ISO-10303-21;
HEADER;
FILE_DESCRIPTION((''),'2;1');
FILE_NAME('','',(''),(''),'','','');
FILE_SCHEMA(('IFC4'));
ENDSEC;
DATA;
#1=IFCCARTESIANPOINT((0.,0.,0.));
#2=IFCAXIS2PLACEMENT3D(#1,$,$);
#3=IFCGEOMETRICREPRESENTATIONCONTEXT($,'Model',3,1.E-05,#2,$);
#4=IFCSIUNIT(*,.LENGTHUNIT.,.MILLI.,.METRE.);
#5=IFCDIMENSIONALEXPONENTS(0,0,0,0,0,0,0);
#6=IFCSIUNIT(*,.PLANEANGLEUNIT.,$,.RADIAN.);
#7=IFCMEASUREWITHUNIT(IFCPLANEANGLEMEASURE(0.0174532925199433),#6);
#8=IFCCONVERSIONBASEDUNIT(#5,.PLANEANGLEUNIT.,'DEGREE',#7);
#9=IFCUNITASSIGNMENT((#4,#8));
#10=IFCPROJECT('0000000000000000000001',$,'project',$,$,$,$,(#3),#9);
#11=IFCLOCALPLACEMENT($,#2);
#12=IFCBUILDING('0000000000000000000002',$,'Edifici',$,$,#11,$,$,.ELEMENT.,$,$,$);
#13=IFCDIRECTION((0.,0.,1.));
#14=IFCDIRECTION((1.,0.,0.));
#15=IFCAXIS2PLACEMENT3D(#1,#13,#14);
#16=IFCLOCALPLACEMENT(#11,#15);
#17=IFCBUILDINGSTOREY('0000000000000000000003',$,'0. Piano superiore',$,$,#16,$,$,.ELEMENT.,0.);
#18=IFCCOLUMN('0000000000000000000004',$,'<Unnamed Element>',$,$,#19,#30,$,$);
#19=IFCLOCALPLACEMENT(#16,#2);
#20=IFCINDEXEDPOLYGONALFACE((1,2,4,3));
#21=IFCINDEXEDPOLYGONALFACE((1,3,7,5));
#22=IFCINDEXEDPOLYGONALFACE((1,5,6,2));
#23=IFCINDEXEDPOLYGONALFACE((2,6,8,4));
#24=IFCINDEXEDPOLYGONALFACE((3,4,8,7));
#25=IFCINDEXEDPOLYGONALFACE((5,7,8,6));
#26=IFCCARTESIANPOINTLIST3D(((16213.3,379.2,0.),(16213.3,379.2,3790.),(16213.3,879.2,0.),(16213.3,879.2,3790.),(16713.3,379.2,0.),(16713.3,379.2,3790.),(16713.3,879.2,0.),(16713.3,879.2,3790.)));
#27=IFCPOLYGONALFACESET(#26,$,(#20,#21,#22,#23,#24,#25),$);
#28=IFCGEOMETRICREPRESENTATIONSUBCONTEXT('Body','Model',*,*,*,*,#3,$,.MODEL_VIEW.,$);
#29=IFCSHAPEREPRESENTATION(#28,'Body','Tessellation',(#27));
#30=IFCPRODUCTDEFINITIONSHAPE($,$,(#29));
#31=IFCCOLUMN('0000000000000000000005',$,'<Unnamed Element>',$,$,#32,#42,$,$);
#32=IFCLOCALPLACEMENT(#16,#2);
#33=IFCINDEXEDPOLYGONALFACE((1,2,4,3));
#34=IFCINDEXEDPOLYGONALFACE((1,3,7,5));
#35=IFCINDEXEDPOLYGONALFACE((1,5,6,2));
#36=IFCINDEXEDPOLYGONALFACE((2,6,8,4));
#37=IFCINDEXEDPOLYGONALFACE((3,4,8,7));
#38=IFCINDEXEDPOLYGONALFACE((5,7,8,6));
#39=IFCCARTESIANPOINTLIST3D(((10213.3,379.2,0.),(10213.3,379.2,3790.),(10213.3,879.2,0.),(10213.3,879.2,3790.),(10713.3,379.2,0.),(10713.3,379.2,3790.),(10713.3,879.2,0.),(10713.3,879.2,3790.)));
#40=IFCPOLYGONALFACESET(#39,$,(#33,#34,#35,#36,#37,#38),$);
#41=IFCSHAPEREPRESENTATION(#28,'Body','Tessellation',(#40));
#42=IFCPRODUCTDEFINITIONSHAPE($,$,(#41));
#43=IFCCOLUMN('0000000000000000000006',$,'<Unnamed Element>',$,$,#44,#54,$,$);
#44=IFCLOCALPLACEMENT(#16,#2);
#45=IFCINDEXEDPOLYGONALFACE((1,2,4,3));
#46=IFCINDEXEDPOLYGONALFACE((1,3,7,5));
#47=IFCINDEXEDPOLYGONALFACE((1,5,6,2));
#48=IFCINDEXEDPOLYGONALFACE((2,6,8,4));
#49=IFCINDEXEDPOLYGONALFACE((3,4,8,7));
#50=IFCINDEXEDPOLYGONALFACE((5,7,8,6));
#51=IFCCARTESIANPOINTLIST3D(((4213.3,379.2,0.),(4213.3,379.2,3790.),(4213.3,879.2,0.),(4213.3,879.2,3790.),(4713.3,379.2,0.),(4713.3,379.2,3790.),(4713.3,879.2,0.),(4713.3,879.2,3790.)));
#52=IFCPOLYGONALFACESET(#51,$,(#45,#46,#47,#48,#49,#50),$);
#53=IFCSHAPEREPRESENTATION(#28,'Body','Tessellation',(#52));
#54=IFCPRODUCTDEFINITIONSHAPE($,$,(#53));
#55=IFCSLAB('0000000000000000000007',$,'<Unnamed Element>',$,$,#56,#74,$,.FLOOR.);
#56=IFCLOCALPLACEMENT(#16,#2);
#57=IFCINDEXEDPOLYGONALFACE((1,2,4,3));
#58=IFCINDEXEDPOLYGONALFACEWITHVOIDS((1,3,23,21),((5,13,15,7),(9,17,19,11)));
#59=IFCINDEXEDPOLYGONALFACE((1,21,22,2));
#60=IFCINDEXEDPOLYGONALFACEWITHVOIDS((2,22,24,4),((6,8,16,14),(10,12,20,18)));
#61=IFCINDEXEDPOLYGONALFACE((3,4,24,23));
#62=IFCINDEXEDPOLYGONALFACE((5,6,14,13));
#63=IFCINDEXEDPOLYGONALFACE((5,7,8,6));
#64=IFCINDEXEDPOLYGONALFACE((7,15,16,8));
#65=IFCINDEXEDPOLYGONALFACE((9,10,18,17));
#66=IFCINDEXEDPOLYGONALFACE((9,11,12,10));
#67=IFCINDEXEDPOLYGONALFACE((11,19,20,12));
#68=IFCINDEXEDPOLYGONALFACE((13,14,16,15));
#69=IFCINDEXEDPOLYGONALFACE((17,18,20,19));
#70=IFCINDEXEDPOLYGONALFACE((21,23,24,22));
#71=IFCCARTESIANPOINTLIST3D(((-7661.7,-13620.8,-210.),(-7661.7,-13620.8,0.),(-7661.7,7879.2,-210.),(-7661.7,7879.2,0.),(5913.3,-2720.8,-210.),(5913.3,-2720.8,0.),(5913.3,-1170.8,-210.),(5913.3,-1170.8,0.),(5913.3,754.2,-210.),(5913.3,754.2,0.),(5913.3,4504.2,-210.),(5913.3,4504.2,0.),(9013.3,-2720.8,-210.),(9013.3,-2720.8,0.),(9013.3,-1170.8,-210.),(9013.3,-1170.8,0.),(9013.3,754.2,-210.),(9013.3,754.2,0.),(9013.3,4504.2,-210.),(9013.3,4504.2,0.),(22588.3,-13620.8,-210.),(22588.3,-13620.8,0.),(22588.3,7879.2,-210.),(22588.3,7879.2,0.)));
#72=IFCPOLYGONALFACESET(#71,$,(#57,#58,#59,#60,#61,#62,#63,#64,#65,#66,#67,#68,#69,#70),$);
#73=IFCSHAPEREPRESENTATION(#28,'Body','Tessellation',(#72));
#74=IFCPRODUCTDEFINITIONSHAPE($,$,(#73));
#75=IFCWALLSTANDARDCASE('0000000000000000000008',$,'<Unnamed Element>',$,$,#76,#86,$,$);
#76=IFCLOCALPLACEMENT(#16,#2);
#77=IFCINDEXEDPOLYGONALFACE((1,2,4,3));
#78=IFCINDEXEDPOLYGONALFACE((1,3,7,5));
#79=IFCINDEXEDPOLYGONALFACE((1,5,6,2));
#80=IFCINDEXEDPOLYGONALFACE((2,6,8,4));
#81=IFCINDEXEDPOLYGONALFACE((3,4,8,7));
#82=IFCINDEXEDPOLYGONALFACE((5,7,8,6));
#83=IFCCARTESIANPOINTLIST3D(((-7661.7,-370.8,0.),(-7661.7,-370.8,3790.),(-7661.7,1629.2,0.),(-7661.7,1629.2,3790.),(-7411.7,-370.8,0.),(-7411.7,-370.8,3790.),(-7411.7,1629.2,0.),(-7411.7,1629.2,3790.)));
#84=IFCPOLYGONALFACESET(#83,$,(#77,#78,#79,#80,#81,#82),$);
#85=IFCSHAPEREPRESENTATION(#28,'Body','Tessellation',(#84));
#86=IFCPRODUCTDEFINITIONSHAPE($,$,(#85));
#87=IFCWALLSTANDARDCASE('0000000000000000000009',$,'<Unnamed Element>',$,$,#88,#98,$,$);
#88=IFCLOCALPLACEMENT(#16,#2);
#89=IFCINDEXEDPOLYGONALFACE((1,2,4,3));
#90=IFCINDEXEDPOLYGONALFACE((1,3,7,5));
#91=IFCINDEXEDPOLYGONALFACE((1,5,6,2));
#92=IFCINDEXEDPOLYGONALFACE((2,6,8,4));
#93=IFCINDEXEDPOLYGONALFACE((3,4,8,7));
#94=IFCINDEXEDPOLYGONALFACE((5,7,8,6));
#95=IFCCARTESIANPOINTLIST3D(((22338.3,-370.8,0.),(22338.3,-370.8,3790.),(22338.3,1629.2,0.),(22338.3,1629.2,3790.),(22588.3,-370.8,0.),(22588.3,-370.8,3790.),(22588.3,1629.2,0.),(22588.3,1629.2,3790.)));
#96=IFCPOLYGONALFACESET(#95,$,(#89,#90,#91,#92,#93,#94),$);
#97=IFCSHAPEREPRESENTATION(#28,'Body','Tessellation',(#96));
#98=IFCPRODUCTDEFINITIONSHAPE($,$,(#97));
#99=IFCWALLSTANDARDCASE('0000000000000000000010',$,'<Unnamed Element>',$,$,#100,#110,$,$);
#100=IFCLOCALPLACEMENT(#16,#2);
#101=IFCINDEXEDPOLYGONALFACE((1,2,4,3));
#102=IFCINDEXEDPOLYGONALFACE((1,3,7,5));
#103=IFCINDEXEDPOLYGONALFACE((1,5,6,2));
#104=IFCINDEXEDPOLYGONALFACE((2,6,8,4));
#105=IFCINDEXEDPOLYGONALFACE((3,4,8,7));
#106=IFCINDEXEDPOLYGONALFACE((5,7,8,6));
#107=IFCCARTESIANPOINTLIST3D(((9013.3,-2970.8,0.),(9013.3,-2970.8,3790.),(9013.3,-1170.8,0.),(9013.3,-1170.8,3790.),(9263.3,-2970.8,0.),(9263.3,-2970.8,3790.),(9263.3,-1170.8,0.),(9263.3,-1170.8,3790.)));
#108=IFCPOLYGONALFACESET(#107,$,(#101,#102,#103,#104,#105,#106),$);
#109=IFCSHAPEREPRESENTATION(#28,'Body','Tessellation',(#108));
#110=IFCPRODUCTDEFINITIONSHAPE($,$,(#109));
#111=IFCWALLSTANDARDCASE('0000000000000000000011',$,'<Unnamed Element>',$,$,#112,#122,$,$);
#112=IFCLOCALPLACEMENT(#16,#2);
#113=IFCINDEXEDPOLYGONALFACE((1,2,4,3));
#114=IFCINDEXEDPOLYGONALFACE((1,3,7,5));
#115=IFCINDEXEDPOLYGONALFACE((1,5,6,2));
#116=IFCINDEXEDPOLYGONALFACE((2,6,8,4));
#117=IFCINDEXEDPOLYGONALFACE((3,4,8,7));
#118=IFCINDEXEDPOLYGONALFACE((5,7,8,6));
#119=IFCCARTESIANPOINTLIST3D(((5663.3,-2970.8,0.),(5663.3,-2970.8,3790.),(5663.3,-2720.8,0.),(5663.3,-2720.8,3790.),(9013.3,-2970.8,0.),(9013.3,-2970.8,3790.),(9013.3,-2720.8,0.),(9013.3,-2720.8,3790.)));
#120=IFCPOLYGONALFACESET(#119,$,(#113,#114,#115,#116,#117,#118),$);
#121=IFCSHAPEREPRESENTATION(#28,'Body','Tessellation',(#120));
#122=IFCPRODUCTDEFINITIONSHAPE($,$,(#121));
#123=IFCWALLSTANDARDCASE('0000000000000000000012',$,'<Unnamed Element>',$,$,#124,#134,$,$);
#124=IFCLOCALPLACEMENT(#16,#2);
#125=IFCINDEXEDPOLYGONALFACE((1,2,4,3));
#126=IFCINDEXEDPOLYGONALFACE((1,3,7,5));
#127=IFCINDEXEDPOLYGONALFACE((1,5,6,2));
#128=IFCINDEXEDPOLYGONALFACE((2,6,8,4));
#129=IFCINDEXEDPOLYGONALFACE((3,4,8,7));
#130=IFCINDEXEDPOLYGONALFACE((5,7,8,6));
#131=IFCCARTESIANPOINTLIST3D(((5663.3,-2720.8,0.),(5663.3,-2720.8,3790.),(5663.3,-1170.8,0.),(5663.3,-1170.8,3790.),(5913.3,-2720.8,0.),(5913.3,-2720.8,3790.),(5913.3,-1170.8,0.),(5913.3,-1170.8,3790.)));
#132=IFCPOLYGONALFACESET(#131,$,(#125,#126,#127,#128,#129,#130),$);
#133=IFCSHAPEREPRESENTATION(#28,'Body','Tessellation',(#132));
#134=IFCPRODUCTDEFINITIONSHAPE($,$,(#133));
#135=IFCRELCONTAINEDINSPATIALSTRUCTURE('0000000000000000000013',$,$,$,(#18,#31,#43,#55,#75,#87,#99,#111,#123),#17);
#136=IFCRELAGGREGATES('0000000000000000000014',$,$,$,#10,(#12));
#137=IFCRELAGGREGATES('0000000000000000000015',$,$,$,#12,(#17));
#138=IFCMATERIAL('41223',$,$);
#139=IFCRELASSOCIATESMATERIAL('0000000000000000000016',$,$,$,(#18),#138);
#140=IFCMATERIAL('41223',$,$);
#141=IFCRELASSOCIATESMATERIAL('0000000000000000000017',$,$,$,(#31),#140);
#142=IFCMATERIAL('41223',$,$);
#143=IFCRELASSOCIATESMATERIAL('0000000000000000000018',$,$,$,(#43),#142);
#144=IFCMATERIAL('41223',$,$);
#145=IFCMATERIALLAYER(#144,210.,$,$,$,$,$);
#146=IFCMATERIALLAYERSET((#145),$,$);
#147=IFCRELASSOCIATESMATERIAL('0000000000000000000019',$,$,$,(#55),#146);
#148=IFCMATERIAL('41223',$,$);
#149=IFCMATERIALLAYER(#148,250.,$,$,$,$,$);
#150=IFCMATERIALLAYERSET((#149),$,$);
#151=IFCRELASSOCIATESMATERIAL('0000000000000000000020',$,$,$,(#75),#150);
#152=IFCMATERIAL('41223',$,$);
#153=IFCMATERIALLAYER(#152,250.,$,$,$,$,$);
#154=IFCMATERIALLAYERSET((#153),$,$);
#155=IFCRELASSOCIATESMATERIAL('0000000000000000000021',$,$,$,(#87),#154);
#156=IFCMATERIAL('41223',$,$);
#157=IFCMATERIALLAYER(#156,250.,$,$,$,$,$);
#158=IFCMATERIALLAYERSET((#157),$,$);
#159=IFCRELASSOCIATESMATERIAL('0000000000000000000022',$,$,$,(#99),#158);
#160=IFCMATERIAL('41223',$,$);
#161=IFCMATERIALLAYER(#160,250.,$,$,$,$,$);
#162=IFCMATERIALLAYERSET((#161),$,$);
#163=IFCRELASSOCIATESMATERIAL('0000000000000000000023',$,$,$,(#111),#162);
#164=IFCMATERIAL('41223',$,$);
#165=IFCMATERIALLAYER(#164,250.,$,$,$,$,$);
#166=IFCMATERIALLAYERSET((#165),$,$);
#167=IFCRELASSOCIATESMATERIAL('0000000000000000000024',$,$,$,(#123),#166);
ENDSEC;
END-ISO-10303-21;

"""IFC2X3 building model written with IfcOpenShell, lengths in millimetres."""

from ifc_helpers import new_model, entity, si_unit, converted_unit, frame, frame_2d, origin, origin_with_axes, place, context, subcontext, project, spatial, polyline, rectangle, outline, extrude, material, layer, layer_set, layer_usage, element, save


model = new_model("IFC2X3")

# Units and contexts
model_context = context("Model", 3, precision=1e-05, world=origin())
body_context = subcontext(model_context, "Body", "Model", "MODEL_VIEW")
ifc_project = project(units=[si_unit("LENGTHUNIT", "METRE", prefix="MILLI"), converted_unit("PLANEANGLEUNIT", "DEGREE", entity("IfcPlaneAngleMeasure", 0.0174532925199433), si_unit("PLANEANGLEUNIT", "RADIAN"), dimensions=[0, 0, 0, 0, 0, 0, 0])], contexts=[model_context])

# Building, storey
building_placement = place(None, origin())
building = spatial("IfcBuilding", under=ifc_project, at=building_placement, Name="Edifici", CompositionType="ELEMENT")
storey_placement = place(building_placement, origin_with_axes())
storey = spatial("IfcBuildingStorey", under=building, at=storey_placement, Name="0. Piano superiore", CompositionType="ELEMENT", Elevation=0.0)

# Columns
ifc_material_1 = material(Name="41223")
column_1_placement = place(storey_placement, frame((16213.3, 379.2, 0.0), z_axis=(0.0, 0.0, 1.0), x_axis=(1.0, 0.0, 0.0)))
element("IfcColumn", 1, at=column_1_placement, inside=storey, material=ifc_material_1, Name="<Unnamed Element>", context=body_context, shape_type="SweptSolid", body=[
    extrude(rectangle(XDim=500.0, YDim=500.0, at=frame_2d((250.0, 250.0), x_axis=(1.0, 0.0))), origin_with_axes(), (0.0, 0.0, 1.0), 3790.0),
])
ifc_material_2 = material(Name="41223")
column_2_placement = place(storey_placement, frame((10213.3, 379.2, 0.0), z_axis=(0.0, 0.0, 1.0), x_axis=(1.0, 0.0, 0.0)))
element("IfcColumn", 2, at=column_2_placement, inside=storey, material=ifc_material_2, Name="<Unnamed Element>", context=body_context, shape_type="SweptSolid", body=[
    extrude(rectangle(XDim=500.0, YDim=500.0, at=frame_2d((250.0, 250.0), x_axis=(1.0, 0.0))), origin_with_axes(), (0.0, 0.0, 1.0), 3790.0),
])
ifc_material_3 = material(Name="41223")
column_3_placement = place(storey_placement, frame((4213.3, 379.2, 0.0), z_axis=(0.0, 0.0, 1.0), x_axis=(1.0, 0.0, 0.0)))
element("IfcColumn", 3, at=column_3_placement, inside=storey, material=ifc_material_3, Name="<Unnamed Element>", context=body_context, shape_type="SweptSolid", body=[
    extrude(rectangle(XDim=500.0, YDim=500.0, at=frame_2d((250.0, 250.0), x_axis=(1.0, 0.0))), origin_with_axes(), (0.0, 0.0, 1.0), 3790.0),
])

# Slab
ifc_material_4 = material(Name="41223")
ifc_layer_1 = layer(ifc_material_4, 210.0)
ifc_layer_set_1 = layer_set([ifc_layer_1])
ifc_layer_usage_1 = layer_usage(ifc_layer_set_1, "AXIS3", "POSITIVE", 0.0)
slab_placement = place(storey_placement, frame((-7661.7, -13620.8, -210.0), z_axis=(0.0, 0.0, 1.0), x_axis=(1.0, 0.0, 0.0)))
element("IfcSlab", 4, at=slab_placement, inside=storey, material=ifc_layer_usage_1, Name="<Unnamed Element>", PredefinedType="FLOOR", context=body_context, shape_type="SweptSolid", body=[
    extrude(outline(polyline([(0.0, 0.0), (30250.0, 0.0), (30250.0, 21500.0), (0.0, 21500.0), (0.0, 0.0)]), holes=[polyline([(13575.0, 18125.0), (16675.0, 18125.0), (16675.0, 14375.0), (13575.0, 14375.0), (13575.0, 18125.0)]), polyline([(16675.0, 10900.0), (13575.0, 10900.0), (13575.0, 12450.0), (16675.0, 12450.0), (16675.0, 10900.0)])]), origin_with_axes(), (0.0, 0.0, 1.0), 210.0),
])

# Walls
ifc_material_5 = material(Name="41223")
ifc_layer_2 = layer(ifc_material_5, 250.0)
ifc_layer_set_2 = layer_set([ifc_layer_2])
ifc_layer_usage_2 = layer_usage(ifc_layer_set_2, "AXIS2", "POSITIVE", 0.0)
wall_1_placement = place(storey_placement, frame((-7661.7, 1629.2, 0.0), z_axis=(0.0, 0.0, 1.0), x_axis=(0.0, -1.0, 0.0)))
element("IfcWallStandardCase", 5, at=wall_1_placement, inside=storey, material=ifc_layer_usage_2, Name="<Unnamed Element>", context=body_context, shape_type="SweptSolid", body=[
    extrude(rectangle(XDim=2000.0, YDim=250.0, at=frame_2d((1000.0, 125.0), x_axis=(1.0, 0.0))), origin_with_axes(), (0.0, 0.0, 1.0), 3790.0),
])
ifc_material_6 = material(Name="41223")
ifc_layer_3 = layer(ifc_material_6, 250.0)
ifc_layer_set_3 = layer_set([ifc_layer_3])
ifc_layer_usage_3 = layer_usage(ifc_layer_set_3, "AXIS2", "POSITIVE", 0.0)
wall_2_placement = place(storey_placement, frame((22338.3, 1629.2, 0.0), z_axis=(0.0, 0.0, 1.0), x_axis=(0.0, -1.0, 0.0)))
element("IfcWallStandardCase", 6, at=wall_2_placement, inside=storey, material=ifc_layer_usage_3, Name="<Unnamed Element>", context=body_context, shape_type="SweptSolid", body=[
    extrude(rectangle(XDim=2000.0, YDim=250.0, at=frame_2d((1000.0, 125.0), x_axis=(1.0, 0.0))), origin_with_axes(), (0.0, 0.0, 1.0), 3790.0),
])
ifc_material_7 = material(Name="41223")
ifc_layer_4 = layer(ifc_material_7, 250.0)
ifc_layer_set_4 = layer_set([ifc_layer_4])
ifc_layer_usage_4 = layer_usage(ifc_layer_set_4, "AXIS2", "POSITIVE", 0.0)
wall_3_placement = place(storey_placement, frame((9263.3, -2970.8, 0.0), z_axis=(0.0, 0.0, 1.0), x_axis=(0.0, 1.0, 0.0)))
element("IfcWallStandardCase", 7, at=wall_3_placement, inside=storey, material=ifc_layer_usage_4, Name="<Unnamed Element>", context=body_context, shape_type="SweptSolid", body=[
    extrude(rectangle(XDim=1800.0, YDim=250.0, at=frame_2d((900.0, 125.0), x_axis=(1.0, 0.0))), origin_with_axes(), (0.0, 0.0, 1.0), 3790.0),
])
ifc_material_8 = material(Name="41223")
ifc_layer_5 = layer(ifc_material_8, 250.0)
ifc_layer_set_5 = layer_set([ifc_layer_5])
ifc_layer_usage_5 = layer_usage(ifc_layer_set_5, "AXIS2", "POSITIVE", 0.0)
wall_4_placement = place(storey_placement, frame((5663.3, -2970.8, 0.0), z_axis=(0.0, 0.0, 1.0), x_axis=(1.0, 0.0, 0.0)))
element("IfcWallStandardCase", 8, at=wall_4_placement, inside=storey, material=ifc_layer_usage_5, Name="<Unnamed Element>", context=body_context, shape_type="SweptSolid", body=[
    extrude(rectangle(XDim=3350.0, YDim=250.0, at=frame_2d((1675.0, 125.0), x_axis=(1.0, 0.0))), origin_with_axes(), (0.0, 0.0, 1.0), 3790.0),
])
ifc_material_9 = material(Name="41223")
ifc_layer_6 = layer(ifc_material_9, 250.0)
ifc_layer_set_6 = layer_set([ifc_layer_6])
ifc_layer_usage_6 = layer_usage(ifc_layer_set_6, "AXIS2", "POSITIVE", 0.0)
wall_5_placement = place(storey_placement, frame((5663.3, -1170.8, 0.0), z_axis=(0.0, 0.0, 1.0), x_axis=(0.0, -1.0, 0.0)))
element("IfcWallStandardCase", 9, at=wall_5_placement, inside=storey, material=ifc_layer_usage_6, Name="<Unnamed Element>", context=body_context, shape_type="SweptSolid", body=[
    extrude(rectangle(XDim=1550.0, YDim=250.0, at=frame_2d((775.0, 125.0), x_axis=(1.0, 0.0))), origin_with_axes(), (0.0, 0.0, 1.0), 3790.0),
])

save(model, "model.ifc")
